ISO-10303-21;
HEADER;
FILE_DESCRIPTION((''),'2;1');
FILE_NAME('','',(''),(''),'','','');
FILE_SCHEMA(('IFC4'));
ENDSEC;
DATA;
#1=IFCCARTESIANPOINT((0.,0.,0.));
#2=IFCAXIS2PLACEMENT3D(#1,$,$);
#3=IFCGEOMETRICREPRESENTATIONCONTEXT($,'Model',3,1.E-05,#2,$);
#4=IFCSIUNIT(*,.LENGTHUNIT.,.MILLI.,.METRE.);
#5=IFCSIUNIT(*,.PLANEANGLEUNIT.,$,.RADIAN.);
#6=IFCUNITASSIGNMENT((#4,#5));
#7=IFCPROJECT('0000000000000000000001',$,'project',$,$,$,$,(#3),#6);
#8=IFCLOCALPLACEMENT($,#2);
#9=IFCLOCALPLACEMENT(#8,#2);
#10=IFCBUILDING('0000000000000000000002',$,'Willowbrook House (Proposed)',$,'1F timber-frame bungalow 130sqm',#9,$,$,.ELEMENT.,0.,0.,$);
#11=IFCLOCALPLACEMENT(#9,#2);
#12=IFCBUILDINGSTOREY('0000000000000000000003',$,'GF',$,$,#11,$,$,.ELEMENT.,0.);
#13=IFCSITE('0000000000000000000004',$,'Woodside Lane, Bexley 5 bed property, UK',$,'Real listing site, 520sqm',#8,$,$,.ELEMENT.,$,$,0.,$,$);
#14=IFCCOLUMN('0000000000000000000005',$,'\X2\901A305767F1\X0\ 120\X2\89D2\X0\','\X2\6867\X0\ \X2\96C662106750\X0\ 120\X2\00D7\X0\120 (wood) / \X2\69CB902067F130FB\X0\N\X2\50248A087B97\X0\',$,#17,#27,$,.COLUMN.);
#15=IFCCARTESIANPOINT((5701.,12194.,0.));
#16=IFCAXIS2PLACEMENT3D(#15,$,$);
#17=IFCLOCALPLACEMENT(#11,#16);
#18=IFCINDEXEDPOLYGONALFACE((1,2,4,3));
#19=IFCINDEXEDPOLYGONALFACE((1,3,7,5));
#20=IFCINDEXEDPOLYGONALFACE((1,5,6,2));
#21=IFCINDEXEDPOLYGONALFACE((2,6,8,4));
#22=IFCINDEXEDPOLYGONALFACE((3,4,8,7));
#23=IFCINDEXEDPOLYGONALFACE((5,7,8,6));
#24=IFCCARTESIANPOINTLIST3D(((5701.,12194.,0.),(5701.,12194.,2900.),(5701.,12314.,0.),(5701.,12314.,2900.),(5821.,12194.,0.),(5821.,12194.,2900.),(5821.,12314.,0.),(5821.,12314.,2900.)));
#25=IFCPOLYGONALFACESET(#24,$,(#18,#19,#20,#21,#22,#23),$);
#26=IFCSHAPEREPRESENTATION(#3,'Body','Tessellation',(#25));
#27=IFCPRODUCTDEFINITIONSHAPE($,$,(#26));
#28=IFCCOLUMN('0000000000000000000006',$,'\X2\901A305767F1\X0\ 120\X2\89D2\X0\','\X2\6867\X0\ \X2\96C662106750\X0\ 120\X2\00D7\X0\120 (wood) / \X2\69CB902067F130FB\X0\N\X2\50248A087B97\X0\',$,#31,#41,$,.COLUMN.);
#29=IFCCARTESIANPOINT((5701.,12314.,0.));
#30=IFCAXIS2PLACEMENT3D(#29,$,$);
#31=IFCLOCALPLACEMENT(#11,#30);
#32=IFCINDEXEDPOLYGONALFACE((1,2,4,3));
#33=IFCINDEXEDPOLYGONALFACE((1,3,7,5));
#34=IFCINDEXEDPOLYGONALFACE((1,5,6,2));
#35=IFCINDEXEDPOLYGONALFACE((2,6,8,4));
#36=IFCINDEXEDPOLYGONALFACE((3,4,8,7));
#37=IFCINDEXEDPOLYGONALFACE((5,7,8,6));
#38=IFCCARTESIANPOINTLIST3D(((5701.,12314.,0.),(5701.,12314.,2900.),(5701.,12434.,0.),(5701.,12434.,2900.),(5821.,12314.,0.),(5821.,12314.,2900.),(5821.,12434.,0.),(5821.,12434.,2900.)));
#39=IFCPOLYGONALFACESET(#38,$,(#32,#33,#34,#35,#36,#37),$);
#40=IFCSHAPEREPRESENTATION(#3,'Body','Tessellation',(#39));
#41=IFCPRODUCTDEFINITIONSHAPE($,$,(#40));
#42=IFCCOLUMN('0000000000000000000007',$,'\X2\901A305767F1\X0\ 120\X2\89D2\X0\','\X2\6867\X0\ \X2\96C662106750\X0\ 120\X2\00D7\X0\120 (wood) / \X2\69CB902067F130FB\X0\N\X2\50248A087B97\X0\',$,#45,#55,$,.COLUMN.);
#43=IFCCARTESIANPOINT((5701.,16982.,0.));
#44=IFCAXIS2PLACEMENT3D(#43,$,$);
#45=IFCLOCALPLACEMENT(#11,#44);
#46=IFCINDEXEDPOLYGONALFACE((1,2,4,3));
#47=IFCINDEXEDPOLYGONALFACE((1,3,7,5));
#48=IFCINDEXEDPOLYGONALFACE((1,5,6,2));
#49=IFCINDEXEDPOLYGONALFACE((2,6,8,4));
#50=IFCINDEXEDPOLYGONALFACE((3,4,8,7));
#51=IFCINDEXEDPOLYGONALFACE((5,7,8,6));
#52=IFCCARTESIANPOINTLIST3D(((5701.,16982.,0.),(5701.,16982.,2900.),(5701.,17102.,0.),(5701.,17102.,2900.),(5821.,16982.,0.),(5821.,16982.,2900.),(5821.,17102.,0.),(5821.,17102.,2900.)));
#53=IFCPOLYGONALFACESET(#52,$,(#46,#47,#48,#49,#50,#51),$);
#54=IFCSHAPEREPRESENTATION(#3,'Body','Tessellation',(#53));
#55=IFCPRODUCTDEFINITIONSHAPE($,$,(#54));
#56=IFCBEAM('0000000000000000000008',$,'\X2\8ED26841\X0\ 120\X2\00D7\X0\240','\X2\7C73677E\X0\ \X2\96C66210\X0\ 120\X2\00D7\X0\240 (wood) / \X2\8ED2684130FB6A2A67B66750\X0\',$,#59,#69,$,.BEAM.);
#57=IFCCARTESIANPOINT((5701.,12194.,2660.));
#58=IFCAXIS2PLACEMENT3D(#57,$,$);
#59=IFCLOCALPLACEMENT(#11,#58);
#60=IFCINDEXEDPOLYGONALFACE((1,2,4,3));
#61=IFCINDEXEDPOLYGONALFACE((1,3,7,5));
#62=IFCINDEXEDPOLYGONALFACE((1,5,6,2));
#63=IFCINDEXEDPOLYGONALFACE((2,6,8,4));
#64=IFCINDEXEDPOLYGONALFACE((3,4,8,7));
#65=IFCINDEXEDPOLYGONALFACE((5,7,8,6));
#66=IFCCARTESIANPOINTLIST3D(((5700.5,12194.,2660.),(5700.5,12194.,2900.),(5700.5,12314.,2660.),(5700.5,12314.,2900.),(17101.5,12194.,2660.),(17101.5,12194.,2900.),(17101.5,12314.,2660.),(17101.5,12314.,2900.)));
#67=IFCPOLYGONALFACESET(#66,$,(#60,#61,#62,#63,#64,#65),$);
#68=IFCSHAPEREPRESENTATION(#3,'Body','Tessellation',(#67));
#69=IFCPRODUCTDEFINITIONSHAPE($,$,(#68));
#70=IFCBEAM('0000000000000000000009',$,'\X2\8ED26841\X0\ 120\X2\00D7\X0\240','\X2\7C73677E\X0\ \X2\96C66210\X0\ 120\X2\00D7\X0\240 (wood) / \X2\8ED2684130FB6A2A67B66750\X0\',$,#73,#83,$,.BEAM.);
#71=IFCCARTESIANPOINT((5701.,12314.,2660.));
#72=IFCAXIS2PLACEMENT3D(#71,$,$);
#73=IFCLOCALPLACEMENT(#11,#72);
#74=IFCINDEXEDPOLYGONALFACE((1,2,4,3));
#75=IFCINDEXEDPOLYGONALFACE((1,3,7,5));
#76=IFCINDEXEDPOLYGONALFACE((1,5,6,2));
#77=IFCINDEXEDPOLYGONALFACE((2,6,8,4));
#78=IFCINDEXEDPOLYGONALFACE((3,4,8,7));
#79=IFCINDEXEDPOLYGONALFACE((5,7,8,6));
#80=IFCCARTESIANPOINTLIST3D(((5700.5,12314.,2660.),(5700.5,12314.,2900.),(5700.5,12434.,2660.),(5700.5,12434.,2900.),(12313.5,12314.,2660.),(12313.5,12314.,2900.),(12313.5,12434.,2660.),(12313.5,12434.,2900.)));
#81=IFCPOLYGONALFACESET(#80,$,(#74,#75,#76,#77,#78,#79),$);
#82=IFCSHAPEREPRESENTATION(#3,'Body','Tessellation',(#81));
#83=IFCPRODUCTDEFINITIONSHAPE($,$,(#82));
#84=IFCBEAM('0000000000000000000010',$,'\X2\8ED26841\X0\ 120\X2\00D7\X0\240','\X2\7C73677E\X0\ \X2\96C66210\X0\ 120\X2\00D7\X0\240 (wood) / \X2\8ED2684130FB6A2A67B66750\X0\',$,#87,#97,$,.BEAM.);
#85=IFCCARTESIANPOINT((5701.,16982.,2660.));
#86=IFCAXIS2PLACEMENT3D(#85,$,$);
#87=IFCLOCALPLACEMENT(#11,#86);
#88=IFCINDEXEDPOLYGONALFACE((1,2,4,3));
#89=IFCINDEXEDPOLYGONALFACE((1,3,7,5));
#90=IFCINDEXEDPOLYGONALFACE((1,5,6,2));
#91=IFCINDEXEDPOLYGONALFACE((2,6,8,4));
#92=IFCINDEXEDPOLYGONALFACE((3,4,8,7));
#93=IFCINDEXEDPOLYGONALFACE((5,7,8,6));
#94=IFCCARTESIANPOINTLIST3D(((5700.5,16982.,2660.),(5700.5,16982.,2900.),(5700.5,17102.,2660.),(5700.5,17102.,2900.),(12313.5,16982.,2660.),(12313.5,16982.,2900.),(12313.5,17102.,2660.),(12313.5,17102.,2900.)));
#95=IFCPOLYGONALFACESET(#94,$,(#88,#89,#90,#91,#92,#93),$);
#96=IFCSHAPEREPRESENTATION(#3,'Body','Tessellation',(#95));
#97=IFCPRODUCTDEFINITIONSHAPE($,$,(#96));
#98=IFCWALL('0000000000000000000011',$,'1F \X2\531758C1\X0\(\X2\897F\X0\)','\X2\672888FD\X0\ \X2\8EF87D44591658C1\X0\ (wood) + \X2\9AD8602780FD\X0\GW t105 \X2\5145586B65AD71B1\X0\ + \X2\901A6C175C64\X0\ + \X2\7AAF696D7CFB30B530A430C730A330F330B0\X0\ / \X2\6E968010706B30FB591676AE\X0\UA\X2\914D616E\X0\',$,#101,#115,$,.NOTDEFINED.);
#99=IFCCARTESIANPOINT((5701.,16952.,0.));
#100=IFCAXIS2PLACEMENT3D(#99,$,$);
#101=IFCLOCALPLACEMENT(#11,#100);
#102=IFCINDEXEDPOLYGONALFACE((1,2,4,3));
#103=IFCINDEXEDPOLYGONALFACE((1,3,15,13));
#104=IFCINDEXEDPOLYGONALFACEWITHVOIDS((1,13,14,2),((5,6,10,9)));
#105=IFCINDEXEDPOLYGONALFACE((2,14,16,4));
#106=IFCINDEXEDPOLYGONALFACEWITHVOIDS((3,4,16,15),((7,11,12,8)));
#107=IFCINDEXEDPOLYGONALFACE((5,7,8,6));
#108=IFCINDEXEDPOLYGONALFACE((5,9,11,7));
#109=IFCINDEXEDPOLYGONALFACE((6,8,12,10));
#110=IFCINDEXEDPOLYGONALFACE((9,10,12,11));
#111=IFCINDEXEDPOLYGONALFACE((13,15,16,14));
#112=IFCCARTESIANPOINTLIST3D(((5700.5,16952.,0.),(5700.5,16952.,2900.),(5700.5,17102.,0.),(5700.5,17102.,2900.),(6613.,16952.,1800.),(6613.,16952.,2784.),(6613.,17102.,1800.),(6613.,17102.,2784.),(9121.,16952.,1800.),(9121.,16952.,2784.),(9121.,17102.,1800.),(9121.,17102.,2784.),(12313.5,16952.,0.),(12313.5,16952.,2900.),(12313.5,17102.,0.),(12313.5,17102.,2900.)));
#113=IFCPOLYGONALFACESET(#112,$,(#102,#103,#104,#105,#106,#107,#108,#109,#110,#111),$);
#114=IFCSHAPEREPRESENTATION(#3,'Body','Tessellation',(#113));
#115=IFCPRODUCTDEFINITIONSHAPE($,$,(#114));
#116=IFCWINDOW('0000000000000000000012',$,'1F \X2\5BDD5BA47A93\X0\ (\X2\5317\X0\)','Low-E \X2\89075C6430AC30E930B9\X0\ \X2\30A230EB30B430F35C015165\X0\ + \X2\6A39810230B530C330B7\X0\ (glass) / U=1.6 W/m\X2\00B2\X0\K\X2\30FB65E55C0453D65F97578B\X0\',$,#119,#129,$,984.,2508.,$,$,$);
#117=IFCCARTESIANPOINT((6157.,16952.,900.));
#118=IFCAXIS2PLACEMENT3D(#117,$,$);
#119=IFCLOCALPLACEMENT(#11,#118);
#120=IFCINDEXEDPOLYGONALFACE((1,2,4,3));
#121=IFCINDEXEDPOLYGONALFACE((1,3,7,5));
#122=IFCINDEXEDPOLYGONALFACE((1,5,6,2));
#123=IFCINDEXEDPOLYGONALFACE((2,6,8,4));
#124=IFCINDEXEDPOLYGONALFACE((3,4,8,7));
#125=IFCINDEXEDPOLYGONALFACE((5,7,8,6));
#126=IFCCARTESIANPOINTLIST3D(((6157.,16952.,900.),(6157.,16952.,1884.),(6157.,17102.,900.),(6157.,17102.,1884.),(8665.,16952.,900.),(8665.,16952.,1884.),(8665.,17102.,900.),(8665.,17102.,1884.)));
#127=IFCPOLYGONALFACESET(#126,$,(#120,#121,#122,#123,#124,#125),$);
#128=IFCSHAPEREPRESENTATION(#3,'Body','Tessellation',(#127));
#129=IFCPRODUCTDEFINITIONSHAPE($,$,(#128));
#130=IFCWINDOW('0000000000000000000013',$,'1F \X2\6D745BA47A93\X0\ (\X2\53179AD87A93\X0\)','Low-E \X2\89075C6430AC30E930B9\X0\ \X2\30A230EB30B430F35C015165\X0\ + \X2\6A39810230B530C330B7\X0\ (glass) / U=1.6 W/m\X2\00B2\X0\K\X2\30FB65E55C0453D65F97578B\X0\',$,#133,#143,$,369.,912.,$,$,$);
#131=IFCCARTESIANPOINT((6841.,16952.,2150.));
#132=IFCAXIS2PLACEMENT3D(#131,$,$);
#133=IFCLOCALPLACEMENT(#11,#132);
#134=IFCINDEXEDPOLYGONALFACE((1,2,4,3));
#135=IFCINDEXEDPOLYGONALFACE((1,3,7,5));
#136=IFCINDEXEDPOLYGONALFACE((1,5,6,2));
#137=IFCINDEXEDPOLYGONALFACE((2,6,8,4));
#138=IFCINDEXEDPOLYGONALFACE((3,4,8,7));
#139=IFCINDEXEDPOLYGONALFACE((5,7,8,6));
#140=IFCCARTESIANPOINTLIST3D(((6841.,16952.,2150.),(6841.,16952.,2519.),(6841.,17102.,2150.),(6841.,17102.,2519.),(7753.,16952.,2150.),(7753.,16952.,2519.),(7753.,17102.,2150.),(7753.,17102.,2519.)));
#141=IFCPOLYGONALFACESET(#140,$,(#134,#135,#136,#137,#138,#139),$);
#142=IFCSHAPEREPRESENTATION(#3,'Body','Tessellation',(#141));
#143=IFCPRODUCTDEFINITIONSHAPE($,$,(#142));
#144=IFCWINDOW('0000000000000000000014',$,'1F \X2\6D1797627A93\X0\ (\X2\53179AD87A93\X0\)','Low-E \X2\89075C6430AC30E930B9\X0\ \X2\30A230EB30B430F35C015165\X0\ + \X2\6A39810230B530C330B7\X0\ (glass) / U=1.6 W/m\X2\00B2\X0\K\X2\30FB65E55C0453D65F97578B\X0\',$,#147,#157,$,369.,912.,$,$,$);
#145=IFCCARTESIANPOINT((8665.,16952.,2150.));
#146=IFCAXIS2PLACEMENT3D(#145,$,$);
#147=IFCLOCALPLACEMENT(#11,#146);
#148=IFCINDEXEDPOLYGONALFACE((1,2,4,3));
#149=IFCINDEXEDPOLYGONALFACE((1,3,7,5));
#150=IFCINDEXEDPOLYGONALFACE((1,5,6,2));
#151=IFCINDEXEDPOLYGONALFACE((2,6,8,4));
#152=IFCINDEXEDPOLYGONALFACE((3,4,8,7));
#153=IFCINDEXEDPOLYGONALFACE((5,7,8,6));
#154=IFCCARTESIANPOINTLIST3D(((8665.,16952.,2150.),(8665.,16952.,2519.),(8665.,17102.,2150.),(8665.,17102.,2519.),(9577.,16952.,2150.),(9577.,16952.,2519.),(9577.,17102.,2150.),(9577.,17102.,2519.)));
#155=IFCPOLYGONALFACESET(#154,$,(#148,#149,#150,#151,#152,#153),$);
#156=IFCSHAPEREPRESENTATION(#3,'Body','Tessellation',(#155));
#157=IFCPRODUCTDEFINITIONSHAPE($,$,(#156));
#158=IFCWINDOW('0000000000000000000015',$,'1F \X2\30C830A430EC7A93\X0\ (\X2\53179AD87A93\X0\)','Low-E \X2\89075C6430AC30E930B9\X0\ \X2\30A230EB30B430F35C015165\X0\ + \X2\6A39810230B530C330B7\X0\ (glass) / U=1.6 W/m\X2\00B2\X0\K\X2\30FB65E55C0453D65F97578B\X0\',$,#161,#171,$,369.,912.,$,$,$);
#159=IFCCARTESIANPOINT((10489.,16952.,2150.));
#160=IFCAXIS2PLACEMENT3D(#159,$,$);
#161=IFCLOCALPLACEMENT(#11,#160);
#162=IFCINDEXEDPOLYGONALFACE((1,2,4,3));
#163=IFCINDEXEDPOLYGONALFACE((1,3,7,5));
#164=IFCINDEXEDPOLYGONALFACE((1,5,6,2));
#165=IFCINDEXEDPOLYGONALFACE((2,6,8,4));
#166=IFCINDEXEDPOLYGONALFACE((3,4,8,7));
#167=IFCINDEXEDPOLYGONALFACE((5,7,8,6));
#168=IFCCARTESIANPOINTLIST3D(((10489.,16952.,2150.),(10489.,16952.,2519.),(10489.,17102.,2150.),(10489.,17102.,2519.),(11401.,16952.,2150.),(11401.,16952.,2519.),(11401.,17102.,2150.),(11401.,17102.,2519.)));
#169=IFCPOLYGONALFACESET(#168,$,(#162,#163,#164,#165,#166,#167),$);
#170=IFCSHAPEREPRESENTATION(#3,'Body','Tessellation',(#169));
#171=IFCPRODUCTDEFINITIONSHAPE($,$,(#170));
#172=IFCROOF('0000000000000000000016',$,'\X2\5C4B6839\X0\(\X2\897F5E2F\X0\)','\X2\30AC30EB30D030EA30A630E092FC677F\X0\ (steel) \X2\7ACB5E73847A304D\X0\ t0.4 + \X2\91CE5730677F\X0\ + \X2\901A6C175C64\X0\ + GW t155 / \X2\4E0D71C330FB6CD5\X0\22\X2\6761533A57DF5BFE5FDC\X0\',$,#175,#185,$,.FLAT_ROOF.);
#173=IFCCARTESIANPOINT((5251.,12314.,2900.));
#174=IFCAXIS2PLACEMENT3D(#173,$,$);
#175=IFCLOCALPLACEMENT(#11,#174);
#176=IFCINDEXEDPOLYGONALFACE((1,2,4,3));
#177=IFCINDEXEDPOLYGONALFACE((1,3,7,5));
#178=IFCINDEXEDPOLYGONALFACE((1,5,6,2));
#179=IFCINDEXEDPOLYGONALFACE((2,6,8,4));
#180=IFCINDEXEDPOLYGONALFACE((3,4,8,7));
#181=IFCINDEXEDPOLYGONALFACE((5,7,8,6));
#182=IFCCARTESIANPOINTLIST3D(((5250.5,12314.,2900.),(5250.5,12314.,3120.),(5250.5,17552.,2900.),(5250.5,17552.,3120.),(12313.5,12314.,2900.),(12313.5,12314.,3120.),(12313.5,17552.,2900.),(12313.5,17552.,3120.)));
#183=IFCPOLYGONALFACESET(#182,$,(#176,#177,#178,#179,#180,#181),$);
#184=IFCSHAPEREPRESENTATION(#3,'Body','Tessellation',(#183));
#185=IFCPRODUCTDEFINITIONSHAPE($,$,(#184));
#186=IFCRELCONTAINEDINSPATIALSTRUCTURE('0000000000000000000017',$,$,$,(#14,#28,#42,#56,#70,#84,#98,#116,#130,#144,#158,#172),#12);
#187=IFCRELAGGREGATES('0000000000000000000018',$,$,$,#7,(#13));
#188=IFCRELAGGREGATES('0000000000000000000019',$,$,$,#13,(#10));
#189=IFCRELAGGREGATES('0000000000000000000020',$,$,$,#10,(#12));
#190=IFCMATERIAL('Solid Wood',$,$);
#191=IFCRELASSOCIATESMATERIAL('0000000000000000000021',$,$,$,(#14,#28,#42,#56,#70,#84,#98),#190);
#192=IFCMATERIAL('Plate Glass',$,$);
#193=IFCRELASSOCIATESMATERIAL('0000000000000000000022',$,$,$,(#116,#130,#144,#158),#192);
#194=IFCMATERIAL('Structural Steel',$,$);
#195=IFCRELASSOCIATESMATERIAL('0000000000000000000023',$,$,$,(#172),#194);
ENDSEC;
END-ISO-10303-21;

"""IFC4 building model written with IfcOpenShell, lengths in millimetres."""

from ifc_helpers import new_model, si_unit, frame, frame_2d, origin, place, context, project, spatial, rectangle, extrude, material, element, fill, save


model = new_model("IFC4")

# Units and contexts
model_context = context("Model", 3, precision=1e-05, world=origin())
ifc_project = project(units=[si_unit("LENGTHUNIT", "METRE", prefix="MILLI"), si_unit("PLANEANGLEUNIT", "RADIAN")], contexts=[model_context])

# Site, building, storey
site_placement = place(None, origin())
site = spatial("IfcSite", under=ifc_project, at=site_placement, Name="Woodside Lane, Bexley 5 bed property, UK", ObjectType="Real listing site, 520sqm", CompositionType="ELEMENT", RefElevation=0.0)
building_placement = place(site_placement, origin())
building = spatial("IfcBuilding", under=site, at=building_placement, Name="Willowbrook House (Proposed)", ObjectType="1F timber-frame bungalow 130sqm", CompositionType="ELEMENT", ElevationOfRefHeight=0.0, ElevationOfTerrain=0.0)
storey_placement = place(building_placement, origin())
storey = spatial("IfcBuildingStorey", under=building, at=storey_placement, Name="GF", CompositionType="ELEMENT", Elevation=0.0)

# Columns
ifc_material_1 = material(Name="Solid Wood")
column_1_placement = place(storey_placement, frame((5701.0, 12194.0, 0.0)))
element("IfcColumn", 1, at=column_1_placement, inside=storey, material=ifc_material_1, Name="通し柱 120角", Description="桧 集成材 120×120 (wood) / 構造柱・N値計算", PredefinedType="COLUMN", context=model_context, shape_type="SweptSolid", body=[
    extrude(rectangle(XDim=120.0, YDim=120.0, at=frame_2d((60.0, 60.0))), frame((5701.0, 12194.0, 0.0)), (0.0, 0.0, 1.0), 2900.0),
])
column_2_placement = place(storey_placement, frame((5701.0, 12314.0, 0.0)))
element("IfcColumn", 2, at=column_2_placement, inside=storey, material=ifc_material_1, Name="通し柱 120角", Description="桧 集成材 120×120 (wood) / 構造柱・N値計算", PredefinedType="COLUMN", context=model_context, shape_type="SweptSolid", body=[
    extrude(rectangle(XDim=120.0, YDim=120.0, at=frame_2d((60.0, 60.0))), frame((5701.0, 12314.0, 0.0)), (0.0, 0.0, 1.0), 2900.0),
])
column_3_placement = place(storey_placement, frame((5701.0, 16982.0, 0.0)))
element("IfcColumn", 3, at=column_3_placement, inside=storey, material=ifc_material_1, Name="通し柱 120角", Description="桧 集成材 120×120 (wood) / 構造柱・N値計算", PredefinedType="COLUMN", context=model_context, shape_type="SweptSolid", body=[
    extrude(rectangle(XDim=120.0, YDim=120.0, at=frame_2d((60.0, 60.0))), frame((5701.0, 16982.0, 0.0)), (0.0, 0.0, 1.0), 2900.0),
])

# Beams
beam_1_placement = place(storey_placement, frame((5701.0, 12194.0, 2660.0)))
element("IfcBeam", 4, at=beam_1_placement, inside=storey, material=ifc_material_1, Name="軒桁 120×240", Description="米松 集成 120×240 (wood) / 軒桁・横架材", PredefinedType="BEAM", context=model_context, shape_type="SweptSolid", body=[
    extrude(rectangle(XDim=11401.0, YDim=120.0, at=frame_2d((5700.0, 60.0))), frame((5701.0, 12194.0, 2660.0)), (0.0, 0.0, 1.0), 240.0),
])
beam_2_placement = place(storey_placement, frame((5701.0, 12314.0, 2660.0)))
element("IfcBeam", 5, at=beam_2_placement, inside=storey, material=ifc_material_1, Name="軒桁 120×240", Description="米松 集成 120×240 (wood) / 軒桁・横架材", PredefinedType="BEAM", context=model_context, shape_type="SweptSolid", body=[
    extrude(rectangle(XDim=6613.0, YDim=120.0, at=frame_2d((3306.0, 60.0))), frame((5701.0, 12314.0, 2660.0)), (0.0, 0.0, 1.0), 240.0),
])
beam_3_placement = place(storey_placement, frame((5701.0, 16982.0, 2660.0)))
element("IfcBeam", 6, at=beam_3_placement, inside=storey, material=ifc_material_1, Name="軒桁 120×240", Description="米松 集成 120×240 (wood) / 軒桁・横架材", PredefinedType="BEAM", context=model_context, shape_type="SweptSolid", body=[
    extrude(rectangle(XDim=6613.0, YDim=120.0, at=frame_2d((3306.0, 60.0))), frame((5701.0, 16982.0, 2660.0)), (0.0, 0.0, 1.0), 240.0),
])

# Wall, openings, windows
wall_1_placement = place(storey_placement, frame((5701.0, 16952.0, 0.0)))
wall_1 = element("IfcWall", 7, at=wall_1_placement, inside=storey, material=ifc_material_1, Name="1F 北壁(西)", Description="木製 軸組外壁 (wood) + 高性能GW t105 充填断熱 + 通気層 + 窯業系サイディング / 準耐火・外皮UA配慮", PredefinedType="NOTDEFINED", context=model_context, shape_type="SweptSolid", body=[
    extrude(rectangle(XDim=6613.0, YDim=150.0, at=frame_2d((3306.0, 75.0))), frame((5701.0, 16952.0, 0.0)), (0.0, 0.0, 1.0), 2900.0),
])
opening_1_placement = place(storey_placement, frame((6157.0, 16952.0, 900.0)))
opening_1 = element("IfcOpeningElement", 8, at=opening_1_placement, cuts=wall_1, PredefinedType="NOTDEFINED", context=model_context, shape_type="SweptSolid", body=[
    extrude(rectangle(XDim=2508.0, YDim=150.0, at=frame_2d((1254.0, 75.0))), frame((6157.0, 16952.0, 900.0)), (0.0, 0.0, 1.0), 984.0),
])
opening_2_placement = place(storey_placement, frame((6841.0, 16952.0, 2150.0)))
opening_2 = element("IfcOpeningElement", 9, at=opening_2_placement, cuts=wall_1, PredefinedType="NOTDEFINED", context=model_context, shape_type="SweptSolid", body=[
    extrude(rectangle(XDim=912.0, YDim=150.0, at=frame_2d((456.0, 75.0))), frame((6841.0, 16952.0, 2150.0)), (0.0, 0.0, 1.0), 369.0),
])
opening_3_placement = place(storey_placement, frame((8665.0, 16952.0, 2150.0)))
opening_3 = element("IfcOpeningElement", 10, at=opening_3_placement, cuts=wall_1, PredefinedType="NOTDEFINED", context=model_context, shape_type="SweptSolid", body=[
    extrude(rectangle(XDim=912.0, YDim=150.0, at=frame_2d((456.0, 75.0))), frame((8665.0, 16952.0, 2150.0)), (0.0, 0.0, 1.0), 369.0),
])
opening_4_placement = place(storey_placement, frame((10489.0, 16952.0, 2150.0)))
opening_4 = element("IfcOpeningElement", 11, at=opening_4_placement, cuts=wall_1, PredefinedType="NOTDEFINED", context=model_context, shape_type="SweptSolid", body=[
    extrude(rectangle(XDim=912.0, YDim=150.0, at=frame_2d((456.0, 75.0))), frame((10489.0, 16952.0, 2150.0)), (0.0, 0.0, 1.0), 369.0),
])
ifc_material_2 = material(Name="Plate Glass")
window_1_placement = place(storey_placement, frame((6157.0, 16952.0, 900.0)))
window_1 = element("IfcWindow", 12, at=window_1_placement, inside=storey, material=ifc_material_2, Name="1F 寝室窓 (北)", Description="Low-E 複層ガラス アルゴン封入 + 樹脂サッシ (glass) / U=1.6 W/m²K・日射取得型", OverallHeight=984.0, OverallWidth=2508.0, context=model_context, shape_type="SweptSolid", body=[
    extrude(rectangle(XDim=2508.0, YDim=150.0, at=frame_2d((1254.0, 75.0))), frame((6157.0, 16952.0, 900.0)), (0.0, 0.0, 1.0), 984.0),
])
fill(opening_1, window_1)
window_2_placement = place(storey_placement, frame((6841.0, 16952.0, 2150.0)))
window_2 = element("IfcWindow", 13, at=window_2_placement, inside=storey, material=ifc_material_2, Name="1F 浴室窓 (北高窓)", Description="Low-E 複層ガラス アルゴン封入 + 樹脂サッシ (glass) / U=1.6 W/m²K・日射取得型", OverallHeight=369.0, OverallWidth=912.0, context=model_context, shape_type="SweptSolid", body=[
    extrude(rectangle(XDim=912.0, YDim=150.0, at=frame_2d((456.0, 75.0))), frame((6841.0, 16952.0, 2150.0)), (0.0, 0.0, 1.0), 369.0),
])
fill(opening_2, window_2)
window_3_placement = place(storey_placement, frame((8665.0, 16952.0, 2150.0)))
window_3 = element("IfcWindow", 14, at=window_3_placement, inside=storey, material=ifc_material_2, Name="1F 洗面窓 (北高窓)", Description="Low-E 複層ガラス アルゴン封入 + 樹脂サッシ (glass) / U=1.6 W/m²K・日射取得型", OverallHeight=369.0, OverallWidth=912.0, context=model_context, shape_type="SweptSolid", body=[
    extrude(rectangle(XDim=912.0, YDim=150.0, at=frame_2d((456.0, 75.0))), frame((8665.0, 16952.0, 2150.0)), (0.0, 0.0, 1.0), 369.0),
])
fill(opening_3, window_3)
window_4_placement = place(storey_placement, frame((10489.0, 16952.0, 2150.0)))
window_4 = element("IfcWindow", 15, at=window_4_placement, inside=storey, material=ifc_material_2, Name="1F トイレ窓 (北高窓)", Description="Low-E 複層ガラス アルゴン封入 + 樹脂サッシ (glass) / U=1.6 W/m²K・日射取得型", OverallHeight=369.0, OverallWidth=912.0, context=model_context, shape_type="SweptSolid", body=[
    extrude(rectangle(XDim=912.0, YDim=150.0, at=frame_2d((456.0, 75.0))), frame((10489.0, 16952.0, 2150.0)), (0.0, 0.0, 1.0), 369.0),
])
fill(opening_4, window_4)

# Roof
ifc_material_3 = material(Name="Structural Steel")
roof_placement = place(storey_placement, frame((5251.0, 12314.0, 2900.0)))
element("IfcRoof", 16, at=roof_placement, inside=storey, material=ifc_material_3, Name="屋根(西帯)", Description="ガルバリウム鋼板 (steel) 立平葺き t0.4 + 野地板 + 通気層 + GW t155 / 不燃・法22条区域対応", PredefinedType="FLAT_ROOF", context=model_context, shape_type="SweptSolid", body=[
    extrude(rectangle(XDim=7063.0, YDim=5238.0, at=frame_2d((3531.0, 2619.0))), frame((5251.0, 12314.0, 2900.0)), (0.0, 0.0, 1.0), 220.0),
])

save(model, "model.ifc")
